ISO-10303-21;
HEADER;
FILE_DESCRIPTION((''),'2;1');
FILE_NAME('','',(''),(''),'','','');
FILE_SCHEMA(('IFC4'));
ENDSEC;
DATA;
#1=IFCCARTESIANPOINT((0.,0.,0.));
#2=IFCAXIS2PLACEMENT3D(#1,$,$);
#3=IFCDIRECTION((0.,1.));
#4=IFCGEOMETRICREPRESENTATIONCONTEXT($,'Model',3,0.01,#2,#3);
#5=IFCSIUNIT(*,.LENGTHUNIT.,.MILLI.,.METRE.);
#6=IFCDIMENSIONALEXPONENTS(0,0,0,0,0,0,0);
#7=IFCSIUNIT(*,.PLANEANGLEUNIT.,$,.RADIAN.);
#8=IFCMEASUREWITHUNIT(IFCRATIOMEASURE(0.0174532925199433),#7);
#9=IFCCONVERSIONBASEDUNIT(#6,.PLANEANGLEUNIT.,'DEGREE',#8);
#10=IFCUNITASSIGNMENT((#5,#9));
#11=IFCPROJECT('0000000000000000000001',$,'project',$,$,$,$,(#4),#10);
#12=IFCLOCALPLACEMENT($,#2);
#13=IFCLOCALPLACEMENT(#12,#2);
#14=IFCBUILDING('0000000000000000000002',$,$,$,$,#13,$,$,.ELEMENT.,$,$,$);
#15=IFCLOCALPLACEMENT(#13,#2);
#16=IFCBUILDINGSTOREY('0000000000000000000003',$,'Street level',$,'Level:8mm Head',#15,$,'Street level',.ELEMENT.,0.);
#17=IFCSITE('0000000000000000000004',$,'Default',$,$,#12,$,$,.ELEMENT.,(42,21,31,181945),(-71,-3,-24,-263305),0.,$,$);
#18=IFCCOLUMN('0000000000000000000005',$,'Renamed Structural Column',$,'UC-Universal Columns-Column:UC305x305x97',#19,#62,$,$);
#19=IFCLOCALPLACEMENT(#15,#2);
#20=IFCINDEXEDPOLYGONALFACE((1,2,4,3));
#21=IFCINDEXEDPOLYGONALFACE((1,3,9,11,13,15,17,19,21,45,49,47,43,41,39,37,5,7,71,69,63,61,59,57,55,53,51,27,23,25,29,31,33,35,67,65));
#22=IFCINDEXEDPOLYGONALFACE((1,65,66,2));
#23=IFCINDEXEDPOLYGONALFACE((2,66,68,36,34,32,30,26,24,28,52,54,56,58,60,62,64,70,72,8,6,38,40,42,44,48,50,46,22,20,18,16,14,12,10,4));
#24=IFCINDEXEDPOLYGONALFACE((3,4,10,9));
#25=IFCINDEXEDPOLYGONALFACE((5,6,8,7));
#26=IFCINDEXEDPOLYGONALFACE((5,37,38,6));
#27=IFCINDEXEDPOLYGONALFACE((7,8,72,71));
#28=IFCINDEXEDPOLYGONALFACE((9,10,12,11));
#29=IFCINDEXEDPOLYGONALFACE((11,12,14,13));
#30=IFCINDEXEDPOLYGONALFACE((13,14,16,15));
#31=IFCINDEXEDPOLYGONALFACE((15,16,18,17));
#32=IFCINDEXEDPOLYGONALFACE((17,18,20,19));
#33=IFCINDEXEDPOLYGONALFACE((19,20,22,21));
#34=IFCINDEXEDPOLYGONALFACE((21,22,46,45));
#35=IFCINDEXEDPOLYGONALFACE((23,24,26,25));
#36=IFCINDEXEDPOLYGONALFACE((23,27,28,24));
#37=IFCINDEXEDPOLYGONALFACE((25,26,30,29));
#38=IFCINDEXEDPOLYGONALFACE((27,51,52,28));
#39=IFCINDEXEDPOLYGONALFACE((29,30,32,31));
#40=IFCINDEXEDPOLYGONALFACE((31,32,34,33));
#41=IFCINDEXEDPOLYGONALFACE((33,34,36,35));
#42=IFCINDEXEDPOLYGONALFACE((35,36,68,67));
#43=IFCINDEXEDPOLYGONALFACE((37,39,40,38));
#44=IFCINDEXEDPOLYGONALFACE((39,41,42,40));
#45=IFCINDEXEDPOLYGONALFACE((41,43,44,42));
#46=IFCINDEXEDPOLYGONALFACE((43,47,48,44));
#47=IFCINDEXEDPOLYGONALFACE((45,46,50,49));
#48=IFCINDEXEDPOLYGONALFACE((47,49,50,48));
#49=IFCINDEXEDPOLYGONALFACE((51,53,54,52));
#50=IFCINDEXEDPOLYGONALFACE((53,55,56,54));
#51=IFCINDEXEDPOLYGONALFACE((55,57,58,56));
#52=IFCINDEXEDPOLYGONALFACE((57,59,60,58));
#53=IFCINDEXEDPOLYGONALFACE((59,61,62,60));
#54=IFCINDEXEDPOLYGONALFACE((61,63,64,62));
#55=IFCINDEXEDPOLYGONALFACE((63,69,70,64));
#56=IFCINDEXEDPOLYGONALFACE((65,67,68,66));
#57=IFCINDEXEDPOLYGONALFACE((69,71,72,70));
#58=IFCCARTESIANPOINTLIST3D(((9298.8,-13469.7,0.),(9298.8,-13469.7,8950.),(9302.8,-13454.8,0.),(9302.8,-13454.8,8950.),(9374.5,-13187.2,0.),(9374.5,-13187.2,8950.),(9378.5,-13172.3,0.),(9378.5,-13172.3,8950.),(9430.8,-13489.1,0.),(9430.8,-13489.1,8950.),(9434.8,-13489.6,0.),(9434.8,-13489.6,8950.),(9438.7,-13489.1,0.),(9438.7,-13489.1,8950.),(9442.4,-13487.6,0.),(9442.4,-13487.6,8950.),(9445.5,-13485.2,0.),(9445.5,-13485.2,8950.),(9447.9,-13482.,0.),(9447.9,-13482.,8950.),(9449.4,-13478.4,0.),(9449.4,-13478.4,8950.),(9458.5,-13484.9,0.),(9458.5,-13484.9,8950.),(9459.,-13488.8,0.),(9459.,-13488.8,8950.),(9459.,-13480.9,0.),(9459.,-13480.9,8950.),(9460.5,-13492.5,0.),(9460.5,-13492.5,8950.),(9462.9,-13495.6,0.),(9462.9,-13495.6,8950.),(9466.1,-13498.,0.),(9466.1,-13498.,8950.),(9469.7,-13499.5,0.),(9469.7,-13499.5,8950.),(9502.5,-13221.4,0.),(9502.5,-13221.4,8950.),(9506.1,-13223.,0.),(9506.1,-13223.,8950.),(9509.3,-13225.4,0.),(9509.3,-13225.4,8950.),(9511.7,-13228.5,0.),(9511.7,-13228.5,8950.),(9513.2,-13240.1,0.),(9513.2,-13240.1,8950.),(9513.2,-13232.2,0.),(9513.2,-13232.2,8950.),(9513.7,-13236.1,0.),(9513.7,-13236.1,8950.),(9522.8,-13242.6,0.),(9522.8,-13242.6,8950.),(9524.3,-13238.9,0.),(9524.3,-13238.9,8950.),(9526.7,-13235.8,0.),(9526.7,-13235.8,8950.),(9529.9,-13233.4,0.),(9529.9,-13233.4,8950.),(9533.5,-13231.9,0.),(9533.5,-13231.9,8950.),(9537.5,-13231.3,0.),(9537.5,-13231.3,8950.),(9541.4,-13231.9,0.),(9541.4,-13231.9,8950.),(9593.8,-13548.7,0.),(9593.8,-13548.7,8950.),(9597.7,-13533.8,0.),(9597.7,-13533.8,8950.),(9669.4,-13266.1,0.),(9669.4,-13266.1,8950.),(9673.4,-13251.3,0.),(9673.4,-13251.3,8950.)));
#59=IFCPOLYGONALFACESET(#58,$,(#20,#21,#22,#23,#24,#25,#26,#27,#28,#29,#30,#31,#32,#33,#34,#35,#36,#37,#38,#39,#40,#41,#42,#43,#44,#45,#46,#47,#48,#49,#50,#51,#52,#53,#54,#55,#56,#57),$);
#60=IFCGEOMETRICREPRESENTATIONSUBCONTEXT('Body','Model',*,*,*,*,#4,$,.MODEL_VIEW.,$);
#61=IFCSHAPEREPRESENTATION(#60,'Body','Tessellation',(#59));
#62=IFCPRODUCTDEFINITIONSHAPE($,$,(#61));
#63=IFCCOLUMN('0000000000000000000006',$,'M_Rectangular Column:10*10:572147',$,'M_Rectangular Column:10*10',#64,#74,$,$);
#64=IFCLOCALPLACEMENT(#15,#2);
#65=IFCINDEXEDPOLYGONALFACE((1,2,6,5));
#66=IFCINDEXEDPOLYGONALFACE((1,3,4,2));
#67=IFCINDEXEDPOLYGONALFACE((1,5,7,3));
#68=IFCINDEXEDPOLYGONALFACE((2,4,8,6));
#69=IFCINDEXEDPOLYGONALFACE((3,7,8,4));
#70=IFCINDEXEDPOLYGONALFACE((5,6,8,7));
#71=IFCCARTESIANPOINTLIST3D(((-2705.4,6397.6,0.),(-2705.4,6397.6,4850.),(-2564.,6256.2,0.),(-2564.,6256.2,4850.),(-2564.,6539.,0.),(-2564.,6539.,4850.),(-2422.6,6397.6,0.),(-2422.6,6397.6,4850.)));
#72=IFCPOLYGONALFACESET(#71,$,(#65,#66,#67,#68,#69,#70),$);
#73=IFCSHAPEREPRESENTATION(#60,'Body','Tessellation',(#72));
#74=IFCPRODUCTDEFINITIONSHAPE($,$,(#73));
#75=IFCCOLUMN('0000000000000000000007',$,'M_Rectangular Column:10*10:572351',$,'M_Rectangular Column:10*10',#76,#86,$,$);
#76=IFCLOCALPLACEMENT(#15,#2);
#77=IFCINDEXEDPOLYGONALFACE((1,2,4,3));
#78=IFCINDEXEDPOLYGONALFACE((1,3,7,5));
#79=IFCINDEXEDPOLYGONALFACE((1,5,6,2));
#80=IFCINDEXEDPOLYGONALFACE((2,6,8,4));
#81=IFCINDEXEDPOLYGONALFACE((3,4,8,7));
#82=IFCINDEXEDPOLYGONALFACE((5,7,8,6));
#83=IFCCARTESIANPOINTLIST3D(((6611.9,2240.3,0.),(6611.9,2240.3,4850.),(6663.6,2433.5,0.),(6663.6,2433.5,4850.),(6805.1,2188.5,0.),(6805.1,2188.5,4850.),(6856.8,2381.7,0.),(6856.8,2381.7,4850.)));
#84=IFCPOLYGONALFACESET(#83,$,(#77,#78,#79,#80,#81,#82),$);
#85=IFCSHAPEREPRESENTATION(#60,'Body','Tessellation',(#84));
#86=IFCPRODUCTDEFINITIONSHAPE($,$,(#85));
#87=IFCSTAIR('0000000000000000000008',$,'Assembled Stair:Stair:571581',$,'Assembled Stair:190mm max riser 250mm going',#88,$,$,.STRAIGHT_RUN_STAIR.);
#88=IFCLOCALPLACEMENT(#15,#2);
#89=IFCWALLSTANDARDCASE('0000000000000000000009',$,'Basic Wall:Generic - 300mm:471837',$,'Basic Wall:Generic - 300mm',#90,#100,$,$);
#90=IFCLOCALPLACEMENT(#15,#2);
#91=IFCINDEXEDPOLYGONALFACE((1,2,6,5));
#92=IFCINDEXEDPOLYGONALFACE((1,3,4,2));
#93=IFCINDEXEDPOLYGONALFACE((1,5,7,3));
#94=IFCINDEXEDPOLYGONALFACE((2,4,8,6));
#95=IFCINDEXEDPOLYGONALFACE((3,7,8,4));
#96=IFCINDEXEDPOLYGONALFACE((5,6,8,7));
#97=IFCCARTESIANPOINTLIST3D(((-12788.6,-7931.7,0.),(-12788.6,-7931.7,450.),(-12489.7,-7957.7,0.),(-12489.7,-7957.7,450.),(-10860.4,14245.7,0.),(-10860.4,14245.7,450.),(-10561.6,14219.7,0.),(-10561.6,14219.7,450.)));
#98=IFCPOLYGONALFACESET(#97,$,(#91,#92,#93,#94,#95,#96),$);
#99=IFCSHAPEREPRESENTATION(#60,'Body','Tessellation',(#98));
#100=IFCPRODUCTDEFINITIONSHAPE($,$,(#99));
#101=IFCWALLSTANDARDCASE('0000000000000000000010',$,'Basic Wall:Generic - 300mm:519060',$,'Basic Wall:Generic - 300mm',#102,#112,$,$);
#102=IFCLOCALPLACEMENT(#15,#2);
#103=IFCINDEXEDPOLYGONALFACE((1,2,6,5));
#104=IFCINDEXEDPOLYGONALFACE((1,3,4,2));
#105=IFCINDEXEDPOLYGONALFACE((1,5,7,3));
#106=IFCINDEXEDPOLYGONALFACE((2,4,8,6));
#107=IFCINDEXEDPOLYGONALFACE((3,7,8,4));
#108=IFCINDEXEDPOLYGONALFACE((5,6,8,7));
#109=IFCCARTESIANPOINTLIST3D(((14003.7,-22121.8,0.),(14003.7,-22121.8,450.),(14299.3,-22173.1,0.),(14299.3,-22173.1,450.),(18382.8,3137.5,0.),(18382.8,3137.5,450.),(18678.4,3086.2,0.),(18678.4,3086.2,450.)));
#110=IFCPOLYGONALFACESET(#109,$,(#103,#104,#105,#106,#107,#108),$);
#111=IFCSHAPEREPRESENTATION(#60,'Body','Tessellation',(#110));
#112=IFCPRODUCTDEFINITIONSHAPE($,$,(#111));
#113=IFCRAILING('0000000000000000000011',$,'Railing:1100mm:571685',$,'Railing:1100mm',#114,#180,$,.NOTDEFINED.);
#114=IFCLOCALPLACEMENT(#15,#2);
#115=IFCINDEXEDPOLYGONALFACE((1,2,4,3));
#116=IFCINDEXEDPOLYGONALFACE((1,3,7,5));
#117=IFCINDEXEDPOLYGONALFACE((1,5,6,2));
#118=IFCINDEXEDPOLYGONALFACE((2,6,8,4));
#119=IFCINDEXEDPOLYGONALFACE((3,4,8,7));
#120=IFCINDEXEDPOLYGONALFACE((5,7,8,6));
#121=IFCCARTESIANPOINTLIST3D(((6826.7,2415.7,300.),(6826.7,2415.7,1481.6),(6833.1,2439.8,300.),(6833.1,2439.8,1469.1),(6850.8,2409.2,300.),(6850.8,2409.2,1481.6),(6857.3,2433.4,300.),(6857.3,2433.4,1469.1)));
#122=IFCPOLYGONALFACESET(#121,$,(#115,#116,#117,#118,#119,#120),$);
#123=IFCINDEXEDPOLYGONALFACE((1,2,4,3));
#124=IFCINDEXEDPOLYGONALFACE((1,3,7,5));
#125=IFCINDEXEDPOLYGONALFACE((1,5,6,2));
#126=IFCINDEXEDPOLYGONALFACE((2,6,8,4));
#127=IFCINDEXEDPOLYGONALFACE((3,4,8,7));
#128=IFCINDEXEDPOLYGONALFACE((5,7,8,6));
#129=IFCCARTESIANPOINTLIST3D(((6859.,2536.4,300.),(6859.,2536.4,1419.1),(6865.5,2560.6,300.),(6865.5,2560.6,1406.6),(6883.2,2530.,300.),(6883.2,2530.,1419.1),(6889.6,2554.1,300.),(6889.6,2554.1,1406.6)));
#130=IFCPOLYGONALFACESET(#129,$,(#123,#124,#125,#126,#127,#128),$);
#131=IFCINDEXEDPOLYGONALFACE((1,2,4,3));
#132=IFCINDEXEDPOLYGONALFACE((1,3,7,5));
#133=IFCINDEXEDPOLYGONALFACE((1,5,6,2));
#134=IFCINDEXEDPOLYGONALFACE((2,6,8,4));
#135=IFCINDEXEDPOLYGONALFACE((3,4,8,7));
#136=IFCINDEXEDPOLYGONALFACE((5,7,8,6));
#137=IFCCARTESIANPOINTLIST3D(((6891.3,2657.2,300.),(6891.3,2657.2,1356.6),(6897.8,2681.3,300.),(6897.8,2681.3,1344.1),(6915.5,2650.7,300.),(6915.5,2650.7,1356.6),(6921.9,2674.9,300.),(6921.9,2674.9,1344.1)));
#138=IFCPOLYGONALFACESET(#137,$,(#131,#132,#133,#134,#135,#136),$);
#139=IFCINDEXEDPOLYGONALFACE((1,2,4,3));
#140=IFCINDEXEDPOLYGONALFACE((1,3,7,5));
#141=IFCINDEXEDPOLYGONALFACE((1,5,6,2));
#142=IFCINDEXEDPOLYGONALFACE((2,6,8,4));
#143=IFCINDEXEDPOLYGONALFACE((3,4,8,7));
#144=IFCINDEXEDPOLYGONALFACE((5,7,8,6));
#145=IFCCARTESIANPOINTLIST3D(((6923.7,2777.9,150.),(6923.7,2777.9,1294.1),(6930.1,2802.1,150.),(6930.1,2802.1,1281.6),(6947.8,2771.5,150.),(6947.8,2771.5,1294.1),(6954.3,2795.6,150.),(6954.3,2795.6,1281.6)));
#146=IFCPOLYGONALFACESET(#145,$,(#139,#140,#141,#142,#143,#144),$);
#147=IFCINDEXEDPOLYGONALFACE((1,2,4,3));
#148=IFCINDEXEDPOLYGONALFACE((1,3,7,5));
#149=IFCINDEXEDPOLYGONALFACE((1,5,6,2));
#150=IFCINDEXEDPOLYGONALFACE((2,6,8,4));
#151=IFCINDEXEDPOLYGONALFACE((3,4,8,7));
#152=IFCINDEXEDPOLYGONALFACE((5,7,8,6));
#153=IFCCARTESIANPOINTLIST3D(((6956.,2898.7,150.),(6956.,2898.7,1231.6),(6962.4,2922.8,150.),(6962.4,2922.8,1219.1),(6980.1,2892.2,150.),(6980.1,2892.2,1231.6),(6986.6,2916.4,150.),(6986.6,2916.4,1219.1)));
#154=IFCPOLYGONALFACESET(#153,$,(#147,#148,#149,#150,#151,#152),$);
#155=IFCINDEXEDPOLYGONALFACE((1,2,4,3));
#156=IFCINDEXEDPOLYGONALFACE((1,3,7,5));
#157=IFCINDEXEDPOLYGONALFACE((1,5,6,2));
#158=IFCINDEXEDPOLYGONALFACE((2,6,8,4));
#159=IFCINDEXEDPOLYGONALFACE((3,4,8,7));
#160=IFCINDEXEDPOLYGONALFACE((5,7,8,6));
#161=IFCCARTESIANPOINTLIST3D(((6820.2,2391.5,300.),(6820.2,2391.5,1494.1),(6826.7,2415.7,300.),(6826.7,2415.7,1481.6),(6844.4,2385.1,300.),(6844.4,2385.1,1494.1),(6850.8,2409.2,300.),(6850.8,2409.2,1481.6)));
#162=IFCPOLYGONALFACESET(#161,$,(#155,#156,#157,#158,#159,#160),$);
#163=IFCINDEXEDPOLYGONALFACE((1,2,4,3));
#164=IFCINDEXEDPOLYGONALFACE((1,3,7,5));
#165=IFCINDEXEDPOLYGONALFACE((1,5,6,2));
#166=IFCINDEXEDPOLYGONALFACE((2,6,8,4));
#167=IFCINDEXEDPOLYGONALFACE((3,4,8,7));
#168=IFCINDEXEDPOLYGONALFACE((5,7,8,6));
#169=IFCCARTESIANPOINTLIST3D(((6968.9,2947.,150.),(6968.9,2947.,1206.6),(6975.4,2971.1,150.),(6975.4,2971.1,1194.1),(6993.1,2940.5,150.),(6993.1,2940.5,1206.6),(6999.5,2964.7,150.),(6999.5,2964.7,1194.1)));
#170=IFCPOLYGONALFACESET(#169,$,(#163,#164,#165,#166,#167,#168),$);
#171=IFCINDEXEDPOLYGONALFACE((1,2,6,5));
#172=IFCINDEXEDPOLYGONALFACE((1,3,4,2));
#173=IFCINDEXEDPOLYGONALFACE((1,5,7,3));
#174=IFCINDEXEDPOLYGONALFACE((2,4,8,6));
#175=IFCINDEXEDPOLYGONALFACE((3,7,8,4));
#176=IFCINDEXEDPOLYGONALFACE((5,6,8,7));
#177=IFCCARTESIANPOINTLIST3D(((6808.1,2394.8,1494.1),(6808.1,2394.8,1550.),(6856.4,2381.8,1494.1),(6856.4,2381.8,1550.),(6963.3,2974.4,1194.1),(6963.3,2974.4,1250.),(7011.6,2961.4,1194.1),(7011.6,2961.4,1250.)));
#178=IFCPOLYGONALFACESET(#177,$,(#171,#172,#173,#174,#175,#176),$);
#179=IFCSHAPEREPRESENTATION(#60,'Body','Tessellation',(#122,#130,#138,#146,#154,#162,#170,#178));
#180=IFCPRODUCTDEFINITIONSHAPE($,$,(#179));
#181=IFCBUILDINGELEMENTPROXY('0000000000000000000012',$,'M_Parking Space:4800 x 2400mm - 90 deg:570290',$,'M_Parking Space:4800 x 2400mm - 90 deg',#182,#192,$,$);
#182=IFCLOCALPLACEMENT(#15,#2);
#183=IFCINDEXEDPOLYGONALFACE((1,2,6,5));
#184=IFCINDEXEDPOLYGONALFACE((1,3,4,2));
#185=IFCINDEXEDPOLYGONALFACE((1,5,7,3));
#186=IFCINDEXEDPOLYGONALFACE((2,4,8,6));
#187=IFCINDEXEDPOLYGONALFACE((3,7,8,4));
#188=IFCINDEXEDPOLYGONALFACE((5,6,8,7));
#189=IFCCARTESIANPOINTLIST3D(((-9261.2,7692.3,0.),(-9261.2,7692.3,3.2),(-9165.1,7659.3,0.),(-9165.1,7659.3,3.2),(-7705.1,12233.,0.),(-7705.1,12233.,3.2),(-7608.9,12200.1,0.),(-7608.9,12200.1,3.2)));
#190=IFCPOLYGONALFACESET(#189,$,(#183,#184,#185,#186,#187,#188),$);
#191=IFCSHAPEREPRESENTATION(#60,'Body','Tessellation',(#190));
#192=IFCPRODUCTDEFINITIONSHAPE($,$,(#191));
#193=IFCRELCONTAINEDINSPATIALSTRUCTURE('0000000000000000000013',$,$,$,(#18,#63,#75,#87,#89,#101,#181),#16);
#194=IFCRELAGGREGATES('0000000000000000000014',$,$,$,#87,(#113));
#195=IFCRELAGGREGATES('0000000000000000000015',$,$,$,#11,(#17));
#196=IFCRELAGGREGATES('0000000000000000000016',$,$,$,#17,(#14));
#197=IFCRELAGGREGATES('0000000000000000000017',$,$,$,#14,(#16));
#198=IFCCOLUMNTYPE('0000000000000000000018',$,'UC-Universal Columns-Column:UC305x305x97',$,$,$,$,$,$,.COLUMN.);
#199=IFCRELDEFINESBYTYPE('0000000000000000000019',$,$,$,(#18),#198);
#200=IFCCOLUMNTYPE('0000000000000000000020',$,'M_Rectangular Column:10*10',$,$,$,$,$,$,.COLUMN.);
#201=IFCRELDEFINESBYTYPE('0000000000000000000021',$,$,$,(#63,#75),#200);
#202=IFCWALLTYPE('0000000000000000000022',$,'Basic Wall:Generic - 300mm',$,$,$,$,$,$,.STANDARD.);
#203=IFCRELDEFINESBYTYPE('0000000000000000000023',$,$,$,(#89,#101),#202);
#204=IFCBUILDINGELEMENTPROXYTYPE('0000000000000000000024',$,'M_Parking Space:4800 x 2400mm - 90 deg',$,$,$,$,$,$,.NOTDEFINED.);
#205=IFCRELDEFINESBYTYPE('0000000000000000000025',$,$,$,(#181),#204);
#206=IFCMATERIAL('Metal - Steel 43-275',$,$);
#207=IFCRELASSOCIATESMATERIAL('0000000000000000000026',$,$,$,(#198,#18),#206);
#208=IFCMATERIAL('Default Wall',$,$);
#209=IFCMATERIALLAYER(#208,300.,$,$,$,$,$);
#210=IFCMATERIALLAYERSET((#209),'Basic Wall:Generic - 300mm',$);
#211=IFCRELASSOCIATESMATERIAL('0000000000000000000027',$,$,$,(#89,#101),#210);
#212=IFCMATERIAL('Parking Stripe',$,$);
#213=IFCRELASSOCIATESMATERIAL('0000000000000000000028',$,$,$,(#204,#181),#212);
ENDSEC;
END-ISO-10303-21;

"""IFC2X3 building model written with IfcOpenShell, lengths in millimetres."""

from ifc_helpers import new_model, entity, si_unit, converted_unit, direction, frame, frame_2d, origin, origin_2d_with_axis, place, context, subcontext, project, spatial, polyline, rectangle, i_section, outline, extrude, source, transform, mapped, material, layer, layer_set, layer_usage, type_object, type_shapes, element, aggregate, save


model = new_model("IFC2X3")

# Units and contexts
model_context = context("Model", 3, precision=0.01, world=origin(), true_north=direction((0.0, 1.0)))
body_context = subcontext(model_context, "Body", "Model", "MODEL_VIEW")
ifc_project = project(units=[si_unit("LENGTHUNIT", "METRE", prefix="MILLI"), converted_unit("PLANEANGLEUNIT", "DEGREE", entity("IfcRatioMeasure", 0.0174532925199433), si_unit("PLANEANGLEUNIT", "RADIAN"), dimensions=[0, 0, 0, 0, 0, 0, 0])], contexts=[model_context])

# Site, building, storey
site_placement = place(None, origin())
site = spatial("IfcSite", under=ifc_project, at=site_placement, Name="Default", CompositionType="ELEMENT", RefLatitude=(42, 21, 31, 181945), RefLongitude=(-71, -3, -24, -263305), RefElevation=0.0)
building_placement = place(site_placement, origin())
building = spatial("IfcBuilding", under=site, at=building_placement, CompositionType="ELEMENT")
storey_placement = place(building_placement, origin())
storey = spatial("IfcBuildingStorey", under=building, at=storey_placement, Name="Street level", ObjectType="Level:8mm Head", LongName="Street level", CompositionType="ELEMENT", Elevation=0.0)

# Columns
ifc_material_1 = material(Name="Metal - Steel 43-275")
column_type_1 = type_object("IfcColumnType", Name="UC-Universal Columns-Column:UC305x305x97", PredefinedType="COLUMN", material=ifc_material_1)
shared_shape_1 = source(origin(), body_context, "Body", "SweptSolid", [
    extrude(i_section(OverallWidth=305.3, OverallDepth=307.9, WebThickness=9.9, FlangeThickness=15.4, FilletRadius=15.2, at=frame_2d((0.0, 0.0), x_axis=(0.0, 1.0))), frame((0.0, 0.0, 0.0), z_axis=(0.0, 0.0, 1.0), x_axis=(0.0, -1.0, 0.0)), (0.0, 0.0, 1.0), 8950.0),
])
type_shapes(column_type_1, [shared_shape_1])
column_placement = place(storey_placement, frame((9486.1, -13360.5, 0.0), z_axis=(0.0, 0.0, 1.0), x_axis=(0.965983, -0.258607, 0.0)))
element("IfcColumn", 1, at=column_placement, inside=storey, type_object=column_type_1, material=ifc_material_1, Name="Renamed Structural Column", ObjectType="UC-Universal Columns-Column:UC305x305x97", context=body_context, shape_type="MappedRepresentation", body=[
    mapped(shared_shape_1, transform((0.0, 0.0, 0.0), scale=1.0)),
])
column_type_2 = type_object("IfcColumnType", Name="M_Rectangular Column:10*10", PredefinedType="COLUMN")
shared_shape_2 = source(origin(), body_context, "Body", "SweptSolid", [
    extrude(rectangle(XDim=200.0, YDim=200.0, at=origin_2d_with_axis()), frame((0.0, 0.0, 0.0), z_axis=(0.0, 0.0, 1.0), x_axis=(0.0, -1.0, 0.0)), (0.0, 0.0, 1.0), 4850.0),
])
type_shapes(column_type_2, [shared_shape_2])
for number, where, z_axis, x_axis, name in (
    (2, (-2564.0, 6397.6, 0.0), (0.0, 0.0, 1.0), (0.707107, 0.707107, 0.0), "M_Rectangular Column:10*10:572147"),
    (3, (6734.4, 2311.0, 0.0), (0.0, 0.0, 1.0), (0.258607, 0.965983, 0.0), "M_Rectangular Column:10*10:572351"),
):
    element("IfcColumn", number, at=place(storey_placement, frame(where, z_axis=z_axis, x_axis=x_axis)), inside=storey, type_object=column_type_2, Name=name, ObjectType="M_Rectangular Column:10*10", context=body_context, shape_type="MappedRepresentation", body=[
        mapped(shared_shape_2, transform((0.0, 0.0, 0.0), scale=1.0)),
    ])

# Stair
stair_placement = place(storey_placement, origin())
stair = element("IfcStair", 4, at=stair_placement, inside=storey, Name="Assembled Stair:Stair:571581", ObjectType="Assembled Stair:190mm max riser 250mm going", ShapeType="STRAIGHT_RUN_STAIR")

# Walls
ifc_material_2 = material(Name="Default Wall")
ifc_layer_1 = layer(ifc_material_2, 300.0)
ifc_layer_set_1 = layer_set([ifc_layer_1], Name="Basic Wall:Generic - 300mm")
ifc_layer_usage_1 = layer_usage(ifc_layer_set_1, "AXIS2", "NEGATIVE", 150.0)
wall_type = type_object("IfcWallType", Name="Basic Wall:Generic - 300mm", PredefinedType="STANDARD")
wall_1_placement = place(storey_placement, frame((-10711.0, 14232.7, 0.0), z_axis=(0.0, 0.0, 1.0), x_axis=(-0.086615, -0.996242, 0.0)))
element("IfcWallStandardCase", 5, at=wall_1_placement, inside=storey, type_object=wall_type, material=ifc_layer_usage_1, Name="Basic Wall:Generic - 300mm:471837", ObjectType="Basic Wall:Generic - 300mm", context=body_context, shape_type="SweptSolid", body=[
    extrude(rectangle(XDim=22261.1, YDim=300.0, at=frame_2d((11130.5, 0.0), x_axis=(-1.0, 0.0))), origin(), (0.0, 0.0, 1.0), 450.0),
])
ifc_layer_usage_2 = layer_usage(ifc_layer_set_1, "AXIS2", "NEGATIVE", 150.0)
wall_2_placement = place(storey_placement, frame((14151.5, -22147.4, 0.0), z_axis=(0.0, 0.0, 1.0), x_axis=(0.17082, 0.985302, 0.0)))
element("IfcWallStandardCase", 6, at=wall_2_placement, inside=storey, type_object=wall_type, material=ifc_layer_usage_2, Name="Basic Wall:Generic - 300mm:519060", ObjectType="Basic Wall:Generic - 300mm", context=body_context, shape_type="SweptSolid", body=[
    extrude(rectangle(XDim=25636.1, YDim=300.0, at=frame_2d((12818.0, 0.0), x_axis=(-1.0, 0.0))), origin(), (0.0, 0.0, 1.0), 450.0),
])

# Railing
railing_placement = place(stair_placement, origin())
railing = element("IfcRailing", 7, at=railing_placement, Name="Railing:1100mm:571685", ObjectType="Railing:1100mm", PredefinedType="NOTDEFINED", context=body_context, shape_type="SweptSolid", body=[
    extrude(outline(polyline([(-587.7, -12.5), (581.4, -12.5), (593.9, 12.5), (-587.7, 12.5), (-587.7, -12.5)])), frame((6829.9, 2427.8, 887.7), z_axis=(0.965983, -0.258606, 0.0), x_axis=(0.0, 0.0, 1.0)), (0.0, 0.0, 1.0), 25.0),
    extrude(outline(polyline([(-556.4, -12.5), (550.2, -12.5), (562.7, 12.5), (-556.4, 12.5), (-556.4, -12.5)])), frame((6862.2, 2548.5, 856.4), z_axis=(0.965983, -0.258606, 0.0), x_axis=(0.0, 0.0, 1.0)), (0.0, 0.0, 1.0), 25.0),
    extrude(outline(polyline([(-525.2, -12.5), (518.9, -12.5), (531.4, 12.5), (-525.2, 12.5), (-525.2, -12.5)])), frame((6894.6, 2669.3, 825.2), z_axis=(0.965983, -0.258606, 0.0), x_axis=(0.0, 0.0, 1.0)), (0.0, 0.0, 1.0), 25.0),
    extrude(outline(polyline([(-568.9, -12.5), (562.7, -12.5), (575.2, 12.5), (-568.9, 12.5), (-568.9, -12.5)])), frame((6926.9, 2790.0, 718.9), z_axis=(0.965983, -0.258606, 0.0), x_axis=(0.0, 0.0, 1.0)), (0.0, 0.0, 1.0), 25.0),
    extrude(outline(polyline([(-537.7, -12.5), (531.4, -12.5), (543.9, 12.5), (-537.7, 12.5), (-537.7, -12.5)])), frame((6959.2, 2910.8, 687.7), z_axis=(0.965983, -0.258606, 0.0), x_axis=(0.0, 0.0, 1.0)), (0.0, 0.0, 1.0), 25.0),
    extrude(outline(polyline([(-593.9, -12.5), (587.7, -12.5), (600.2, 12.5), (-593.9, 12.5), (-593.9, -12.5)])), frame((6823.4, 2403.6, 893.9), z_axis=(0.965983, -0.258606, 0.0), x_axis=(0.0, 0.0, 1.0)), (0.0, 0.0, 1.0), 25.0),
    extrude(outline(polyline([(-525.2, -12.5), (518.9, -12.5), (531.4, 12.5), (-525.2, 12.5), (-525.2, -12.5)])), frame((6972.1, 2959.1, 675.2), z_axis=(0.965983, -0.258606, 0.0), x_axis=(0.0, 0.0, 1.0)), (0.0, 0.0, 1.0), 25.0),
    extrude(outline(polyline([(-322.9, -25.0), (347.9, -25.0), (322.9, 25.0), (-347.9, 25.0), (-322.9, -25.0)])), frame((6885.7, 2684.6, 1372.0), z_axis=(0.965983, -0.258606, 0.0), x_axis=(-0.231304, -0.864001, 0.447214)), (0.0, 0.0, 1.0), 50.0),
])
aggregate(stair, [railing])

# Building element proxy
ifc_material_3 = material(Name="Parking Stripe")
building_element_proxy_type = type_object("IfcBuildingElementProxyType", Name="M_Parking Space:4800 x 2400mm - 90 deg", PredefinedType="NOTDEFINED", material=ifc_material_3)
shared_shape_3 = source(origin(), body_context, "Body", "SweptSolid", [
    extrude(rectangle(XDim=101.6, YDim=4800.0, at=origin_2d_with_axis()), frame((0.0, 2400.0, 0.0)), (0.0, 0.0, 1.0), 3.2),
])
type_shapes(building_element_proxy_type, [shared_shape_3])
for number, where, z_axis, x_axis, name in (
    (8, (-9213.1, 7675.8, 0.0), (0.0, 0.0, 1.0), (0.945989, -0.324198, 0.0), "M_Parking Space:4800 x 2400mm - 90 deg:570290"),
):
    element("IfcBuildingElementProxy", number, at=place(storey_placement, frame(where, z_axis=z_axis, x_axis=x_axis)), inside=storey, type_object=building_element_proxy_type, material=ifc_material_3, Name=name, ObjectType="M_Parking Space:4800 x 2400mm - 90 deg", context=body_context, shape_type="MappedRepresentation", body=[
        mapped(shared_shape_3, transform((0.0, 0.0, 0.0), scale=1.0)),
    ])

save(model, "model.ifc")
